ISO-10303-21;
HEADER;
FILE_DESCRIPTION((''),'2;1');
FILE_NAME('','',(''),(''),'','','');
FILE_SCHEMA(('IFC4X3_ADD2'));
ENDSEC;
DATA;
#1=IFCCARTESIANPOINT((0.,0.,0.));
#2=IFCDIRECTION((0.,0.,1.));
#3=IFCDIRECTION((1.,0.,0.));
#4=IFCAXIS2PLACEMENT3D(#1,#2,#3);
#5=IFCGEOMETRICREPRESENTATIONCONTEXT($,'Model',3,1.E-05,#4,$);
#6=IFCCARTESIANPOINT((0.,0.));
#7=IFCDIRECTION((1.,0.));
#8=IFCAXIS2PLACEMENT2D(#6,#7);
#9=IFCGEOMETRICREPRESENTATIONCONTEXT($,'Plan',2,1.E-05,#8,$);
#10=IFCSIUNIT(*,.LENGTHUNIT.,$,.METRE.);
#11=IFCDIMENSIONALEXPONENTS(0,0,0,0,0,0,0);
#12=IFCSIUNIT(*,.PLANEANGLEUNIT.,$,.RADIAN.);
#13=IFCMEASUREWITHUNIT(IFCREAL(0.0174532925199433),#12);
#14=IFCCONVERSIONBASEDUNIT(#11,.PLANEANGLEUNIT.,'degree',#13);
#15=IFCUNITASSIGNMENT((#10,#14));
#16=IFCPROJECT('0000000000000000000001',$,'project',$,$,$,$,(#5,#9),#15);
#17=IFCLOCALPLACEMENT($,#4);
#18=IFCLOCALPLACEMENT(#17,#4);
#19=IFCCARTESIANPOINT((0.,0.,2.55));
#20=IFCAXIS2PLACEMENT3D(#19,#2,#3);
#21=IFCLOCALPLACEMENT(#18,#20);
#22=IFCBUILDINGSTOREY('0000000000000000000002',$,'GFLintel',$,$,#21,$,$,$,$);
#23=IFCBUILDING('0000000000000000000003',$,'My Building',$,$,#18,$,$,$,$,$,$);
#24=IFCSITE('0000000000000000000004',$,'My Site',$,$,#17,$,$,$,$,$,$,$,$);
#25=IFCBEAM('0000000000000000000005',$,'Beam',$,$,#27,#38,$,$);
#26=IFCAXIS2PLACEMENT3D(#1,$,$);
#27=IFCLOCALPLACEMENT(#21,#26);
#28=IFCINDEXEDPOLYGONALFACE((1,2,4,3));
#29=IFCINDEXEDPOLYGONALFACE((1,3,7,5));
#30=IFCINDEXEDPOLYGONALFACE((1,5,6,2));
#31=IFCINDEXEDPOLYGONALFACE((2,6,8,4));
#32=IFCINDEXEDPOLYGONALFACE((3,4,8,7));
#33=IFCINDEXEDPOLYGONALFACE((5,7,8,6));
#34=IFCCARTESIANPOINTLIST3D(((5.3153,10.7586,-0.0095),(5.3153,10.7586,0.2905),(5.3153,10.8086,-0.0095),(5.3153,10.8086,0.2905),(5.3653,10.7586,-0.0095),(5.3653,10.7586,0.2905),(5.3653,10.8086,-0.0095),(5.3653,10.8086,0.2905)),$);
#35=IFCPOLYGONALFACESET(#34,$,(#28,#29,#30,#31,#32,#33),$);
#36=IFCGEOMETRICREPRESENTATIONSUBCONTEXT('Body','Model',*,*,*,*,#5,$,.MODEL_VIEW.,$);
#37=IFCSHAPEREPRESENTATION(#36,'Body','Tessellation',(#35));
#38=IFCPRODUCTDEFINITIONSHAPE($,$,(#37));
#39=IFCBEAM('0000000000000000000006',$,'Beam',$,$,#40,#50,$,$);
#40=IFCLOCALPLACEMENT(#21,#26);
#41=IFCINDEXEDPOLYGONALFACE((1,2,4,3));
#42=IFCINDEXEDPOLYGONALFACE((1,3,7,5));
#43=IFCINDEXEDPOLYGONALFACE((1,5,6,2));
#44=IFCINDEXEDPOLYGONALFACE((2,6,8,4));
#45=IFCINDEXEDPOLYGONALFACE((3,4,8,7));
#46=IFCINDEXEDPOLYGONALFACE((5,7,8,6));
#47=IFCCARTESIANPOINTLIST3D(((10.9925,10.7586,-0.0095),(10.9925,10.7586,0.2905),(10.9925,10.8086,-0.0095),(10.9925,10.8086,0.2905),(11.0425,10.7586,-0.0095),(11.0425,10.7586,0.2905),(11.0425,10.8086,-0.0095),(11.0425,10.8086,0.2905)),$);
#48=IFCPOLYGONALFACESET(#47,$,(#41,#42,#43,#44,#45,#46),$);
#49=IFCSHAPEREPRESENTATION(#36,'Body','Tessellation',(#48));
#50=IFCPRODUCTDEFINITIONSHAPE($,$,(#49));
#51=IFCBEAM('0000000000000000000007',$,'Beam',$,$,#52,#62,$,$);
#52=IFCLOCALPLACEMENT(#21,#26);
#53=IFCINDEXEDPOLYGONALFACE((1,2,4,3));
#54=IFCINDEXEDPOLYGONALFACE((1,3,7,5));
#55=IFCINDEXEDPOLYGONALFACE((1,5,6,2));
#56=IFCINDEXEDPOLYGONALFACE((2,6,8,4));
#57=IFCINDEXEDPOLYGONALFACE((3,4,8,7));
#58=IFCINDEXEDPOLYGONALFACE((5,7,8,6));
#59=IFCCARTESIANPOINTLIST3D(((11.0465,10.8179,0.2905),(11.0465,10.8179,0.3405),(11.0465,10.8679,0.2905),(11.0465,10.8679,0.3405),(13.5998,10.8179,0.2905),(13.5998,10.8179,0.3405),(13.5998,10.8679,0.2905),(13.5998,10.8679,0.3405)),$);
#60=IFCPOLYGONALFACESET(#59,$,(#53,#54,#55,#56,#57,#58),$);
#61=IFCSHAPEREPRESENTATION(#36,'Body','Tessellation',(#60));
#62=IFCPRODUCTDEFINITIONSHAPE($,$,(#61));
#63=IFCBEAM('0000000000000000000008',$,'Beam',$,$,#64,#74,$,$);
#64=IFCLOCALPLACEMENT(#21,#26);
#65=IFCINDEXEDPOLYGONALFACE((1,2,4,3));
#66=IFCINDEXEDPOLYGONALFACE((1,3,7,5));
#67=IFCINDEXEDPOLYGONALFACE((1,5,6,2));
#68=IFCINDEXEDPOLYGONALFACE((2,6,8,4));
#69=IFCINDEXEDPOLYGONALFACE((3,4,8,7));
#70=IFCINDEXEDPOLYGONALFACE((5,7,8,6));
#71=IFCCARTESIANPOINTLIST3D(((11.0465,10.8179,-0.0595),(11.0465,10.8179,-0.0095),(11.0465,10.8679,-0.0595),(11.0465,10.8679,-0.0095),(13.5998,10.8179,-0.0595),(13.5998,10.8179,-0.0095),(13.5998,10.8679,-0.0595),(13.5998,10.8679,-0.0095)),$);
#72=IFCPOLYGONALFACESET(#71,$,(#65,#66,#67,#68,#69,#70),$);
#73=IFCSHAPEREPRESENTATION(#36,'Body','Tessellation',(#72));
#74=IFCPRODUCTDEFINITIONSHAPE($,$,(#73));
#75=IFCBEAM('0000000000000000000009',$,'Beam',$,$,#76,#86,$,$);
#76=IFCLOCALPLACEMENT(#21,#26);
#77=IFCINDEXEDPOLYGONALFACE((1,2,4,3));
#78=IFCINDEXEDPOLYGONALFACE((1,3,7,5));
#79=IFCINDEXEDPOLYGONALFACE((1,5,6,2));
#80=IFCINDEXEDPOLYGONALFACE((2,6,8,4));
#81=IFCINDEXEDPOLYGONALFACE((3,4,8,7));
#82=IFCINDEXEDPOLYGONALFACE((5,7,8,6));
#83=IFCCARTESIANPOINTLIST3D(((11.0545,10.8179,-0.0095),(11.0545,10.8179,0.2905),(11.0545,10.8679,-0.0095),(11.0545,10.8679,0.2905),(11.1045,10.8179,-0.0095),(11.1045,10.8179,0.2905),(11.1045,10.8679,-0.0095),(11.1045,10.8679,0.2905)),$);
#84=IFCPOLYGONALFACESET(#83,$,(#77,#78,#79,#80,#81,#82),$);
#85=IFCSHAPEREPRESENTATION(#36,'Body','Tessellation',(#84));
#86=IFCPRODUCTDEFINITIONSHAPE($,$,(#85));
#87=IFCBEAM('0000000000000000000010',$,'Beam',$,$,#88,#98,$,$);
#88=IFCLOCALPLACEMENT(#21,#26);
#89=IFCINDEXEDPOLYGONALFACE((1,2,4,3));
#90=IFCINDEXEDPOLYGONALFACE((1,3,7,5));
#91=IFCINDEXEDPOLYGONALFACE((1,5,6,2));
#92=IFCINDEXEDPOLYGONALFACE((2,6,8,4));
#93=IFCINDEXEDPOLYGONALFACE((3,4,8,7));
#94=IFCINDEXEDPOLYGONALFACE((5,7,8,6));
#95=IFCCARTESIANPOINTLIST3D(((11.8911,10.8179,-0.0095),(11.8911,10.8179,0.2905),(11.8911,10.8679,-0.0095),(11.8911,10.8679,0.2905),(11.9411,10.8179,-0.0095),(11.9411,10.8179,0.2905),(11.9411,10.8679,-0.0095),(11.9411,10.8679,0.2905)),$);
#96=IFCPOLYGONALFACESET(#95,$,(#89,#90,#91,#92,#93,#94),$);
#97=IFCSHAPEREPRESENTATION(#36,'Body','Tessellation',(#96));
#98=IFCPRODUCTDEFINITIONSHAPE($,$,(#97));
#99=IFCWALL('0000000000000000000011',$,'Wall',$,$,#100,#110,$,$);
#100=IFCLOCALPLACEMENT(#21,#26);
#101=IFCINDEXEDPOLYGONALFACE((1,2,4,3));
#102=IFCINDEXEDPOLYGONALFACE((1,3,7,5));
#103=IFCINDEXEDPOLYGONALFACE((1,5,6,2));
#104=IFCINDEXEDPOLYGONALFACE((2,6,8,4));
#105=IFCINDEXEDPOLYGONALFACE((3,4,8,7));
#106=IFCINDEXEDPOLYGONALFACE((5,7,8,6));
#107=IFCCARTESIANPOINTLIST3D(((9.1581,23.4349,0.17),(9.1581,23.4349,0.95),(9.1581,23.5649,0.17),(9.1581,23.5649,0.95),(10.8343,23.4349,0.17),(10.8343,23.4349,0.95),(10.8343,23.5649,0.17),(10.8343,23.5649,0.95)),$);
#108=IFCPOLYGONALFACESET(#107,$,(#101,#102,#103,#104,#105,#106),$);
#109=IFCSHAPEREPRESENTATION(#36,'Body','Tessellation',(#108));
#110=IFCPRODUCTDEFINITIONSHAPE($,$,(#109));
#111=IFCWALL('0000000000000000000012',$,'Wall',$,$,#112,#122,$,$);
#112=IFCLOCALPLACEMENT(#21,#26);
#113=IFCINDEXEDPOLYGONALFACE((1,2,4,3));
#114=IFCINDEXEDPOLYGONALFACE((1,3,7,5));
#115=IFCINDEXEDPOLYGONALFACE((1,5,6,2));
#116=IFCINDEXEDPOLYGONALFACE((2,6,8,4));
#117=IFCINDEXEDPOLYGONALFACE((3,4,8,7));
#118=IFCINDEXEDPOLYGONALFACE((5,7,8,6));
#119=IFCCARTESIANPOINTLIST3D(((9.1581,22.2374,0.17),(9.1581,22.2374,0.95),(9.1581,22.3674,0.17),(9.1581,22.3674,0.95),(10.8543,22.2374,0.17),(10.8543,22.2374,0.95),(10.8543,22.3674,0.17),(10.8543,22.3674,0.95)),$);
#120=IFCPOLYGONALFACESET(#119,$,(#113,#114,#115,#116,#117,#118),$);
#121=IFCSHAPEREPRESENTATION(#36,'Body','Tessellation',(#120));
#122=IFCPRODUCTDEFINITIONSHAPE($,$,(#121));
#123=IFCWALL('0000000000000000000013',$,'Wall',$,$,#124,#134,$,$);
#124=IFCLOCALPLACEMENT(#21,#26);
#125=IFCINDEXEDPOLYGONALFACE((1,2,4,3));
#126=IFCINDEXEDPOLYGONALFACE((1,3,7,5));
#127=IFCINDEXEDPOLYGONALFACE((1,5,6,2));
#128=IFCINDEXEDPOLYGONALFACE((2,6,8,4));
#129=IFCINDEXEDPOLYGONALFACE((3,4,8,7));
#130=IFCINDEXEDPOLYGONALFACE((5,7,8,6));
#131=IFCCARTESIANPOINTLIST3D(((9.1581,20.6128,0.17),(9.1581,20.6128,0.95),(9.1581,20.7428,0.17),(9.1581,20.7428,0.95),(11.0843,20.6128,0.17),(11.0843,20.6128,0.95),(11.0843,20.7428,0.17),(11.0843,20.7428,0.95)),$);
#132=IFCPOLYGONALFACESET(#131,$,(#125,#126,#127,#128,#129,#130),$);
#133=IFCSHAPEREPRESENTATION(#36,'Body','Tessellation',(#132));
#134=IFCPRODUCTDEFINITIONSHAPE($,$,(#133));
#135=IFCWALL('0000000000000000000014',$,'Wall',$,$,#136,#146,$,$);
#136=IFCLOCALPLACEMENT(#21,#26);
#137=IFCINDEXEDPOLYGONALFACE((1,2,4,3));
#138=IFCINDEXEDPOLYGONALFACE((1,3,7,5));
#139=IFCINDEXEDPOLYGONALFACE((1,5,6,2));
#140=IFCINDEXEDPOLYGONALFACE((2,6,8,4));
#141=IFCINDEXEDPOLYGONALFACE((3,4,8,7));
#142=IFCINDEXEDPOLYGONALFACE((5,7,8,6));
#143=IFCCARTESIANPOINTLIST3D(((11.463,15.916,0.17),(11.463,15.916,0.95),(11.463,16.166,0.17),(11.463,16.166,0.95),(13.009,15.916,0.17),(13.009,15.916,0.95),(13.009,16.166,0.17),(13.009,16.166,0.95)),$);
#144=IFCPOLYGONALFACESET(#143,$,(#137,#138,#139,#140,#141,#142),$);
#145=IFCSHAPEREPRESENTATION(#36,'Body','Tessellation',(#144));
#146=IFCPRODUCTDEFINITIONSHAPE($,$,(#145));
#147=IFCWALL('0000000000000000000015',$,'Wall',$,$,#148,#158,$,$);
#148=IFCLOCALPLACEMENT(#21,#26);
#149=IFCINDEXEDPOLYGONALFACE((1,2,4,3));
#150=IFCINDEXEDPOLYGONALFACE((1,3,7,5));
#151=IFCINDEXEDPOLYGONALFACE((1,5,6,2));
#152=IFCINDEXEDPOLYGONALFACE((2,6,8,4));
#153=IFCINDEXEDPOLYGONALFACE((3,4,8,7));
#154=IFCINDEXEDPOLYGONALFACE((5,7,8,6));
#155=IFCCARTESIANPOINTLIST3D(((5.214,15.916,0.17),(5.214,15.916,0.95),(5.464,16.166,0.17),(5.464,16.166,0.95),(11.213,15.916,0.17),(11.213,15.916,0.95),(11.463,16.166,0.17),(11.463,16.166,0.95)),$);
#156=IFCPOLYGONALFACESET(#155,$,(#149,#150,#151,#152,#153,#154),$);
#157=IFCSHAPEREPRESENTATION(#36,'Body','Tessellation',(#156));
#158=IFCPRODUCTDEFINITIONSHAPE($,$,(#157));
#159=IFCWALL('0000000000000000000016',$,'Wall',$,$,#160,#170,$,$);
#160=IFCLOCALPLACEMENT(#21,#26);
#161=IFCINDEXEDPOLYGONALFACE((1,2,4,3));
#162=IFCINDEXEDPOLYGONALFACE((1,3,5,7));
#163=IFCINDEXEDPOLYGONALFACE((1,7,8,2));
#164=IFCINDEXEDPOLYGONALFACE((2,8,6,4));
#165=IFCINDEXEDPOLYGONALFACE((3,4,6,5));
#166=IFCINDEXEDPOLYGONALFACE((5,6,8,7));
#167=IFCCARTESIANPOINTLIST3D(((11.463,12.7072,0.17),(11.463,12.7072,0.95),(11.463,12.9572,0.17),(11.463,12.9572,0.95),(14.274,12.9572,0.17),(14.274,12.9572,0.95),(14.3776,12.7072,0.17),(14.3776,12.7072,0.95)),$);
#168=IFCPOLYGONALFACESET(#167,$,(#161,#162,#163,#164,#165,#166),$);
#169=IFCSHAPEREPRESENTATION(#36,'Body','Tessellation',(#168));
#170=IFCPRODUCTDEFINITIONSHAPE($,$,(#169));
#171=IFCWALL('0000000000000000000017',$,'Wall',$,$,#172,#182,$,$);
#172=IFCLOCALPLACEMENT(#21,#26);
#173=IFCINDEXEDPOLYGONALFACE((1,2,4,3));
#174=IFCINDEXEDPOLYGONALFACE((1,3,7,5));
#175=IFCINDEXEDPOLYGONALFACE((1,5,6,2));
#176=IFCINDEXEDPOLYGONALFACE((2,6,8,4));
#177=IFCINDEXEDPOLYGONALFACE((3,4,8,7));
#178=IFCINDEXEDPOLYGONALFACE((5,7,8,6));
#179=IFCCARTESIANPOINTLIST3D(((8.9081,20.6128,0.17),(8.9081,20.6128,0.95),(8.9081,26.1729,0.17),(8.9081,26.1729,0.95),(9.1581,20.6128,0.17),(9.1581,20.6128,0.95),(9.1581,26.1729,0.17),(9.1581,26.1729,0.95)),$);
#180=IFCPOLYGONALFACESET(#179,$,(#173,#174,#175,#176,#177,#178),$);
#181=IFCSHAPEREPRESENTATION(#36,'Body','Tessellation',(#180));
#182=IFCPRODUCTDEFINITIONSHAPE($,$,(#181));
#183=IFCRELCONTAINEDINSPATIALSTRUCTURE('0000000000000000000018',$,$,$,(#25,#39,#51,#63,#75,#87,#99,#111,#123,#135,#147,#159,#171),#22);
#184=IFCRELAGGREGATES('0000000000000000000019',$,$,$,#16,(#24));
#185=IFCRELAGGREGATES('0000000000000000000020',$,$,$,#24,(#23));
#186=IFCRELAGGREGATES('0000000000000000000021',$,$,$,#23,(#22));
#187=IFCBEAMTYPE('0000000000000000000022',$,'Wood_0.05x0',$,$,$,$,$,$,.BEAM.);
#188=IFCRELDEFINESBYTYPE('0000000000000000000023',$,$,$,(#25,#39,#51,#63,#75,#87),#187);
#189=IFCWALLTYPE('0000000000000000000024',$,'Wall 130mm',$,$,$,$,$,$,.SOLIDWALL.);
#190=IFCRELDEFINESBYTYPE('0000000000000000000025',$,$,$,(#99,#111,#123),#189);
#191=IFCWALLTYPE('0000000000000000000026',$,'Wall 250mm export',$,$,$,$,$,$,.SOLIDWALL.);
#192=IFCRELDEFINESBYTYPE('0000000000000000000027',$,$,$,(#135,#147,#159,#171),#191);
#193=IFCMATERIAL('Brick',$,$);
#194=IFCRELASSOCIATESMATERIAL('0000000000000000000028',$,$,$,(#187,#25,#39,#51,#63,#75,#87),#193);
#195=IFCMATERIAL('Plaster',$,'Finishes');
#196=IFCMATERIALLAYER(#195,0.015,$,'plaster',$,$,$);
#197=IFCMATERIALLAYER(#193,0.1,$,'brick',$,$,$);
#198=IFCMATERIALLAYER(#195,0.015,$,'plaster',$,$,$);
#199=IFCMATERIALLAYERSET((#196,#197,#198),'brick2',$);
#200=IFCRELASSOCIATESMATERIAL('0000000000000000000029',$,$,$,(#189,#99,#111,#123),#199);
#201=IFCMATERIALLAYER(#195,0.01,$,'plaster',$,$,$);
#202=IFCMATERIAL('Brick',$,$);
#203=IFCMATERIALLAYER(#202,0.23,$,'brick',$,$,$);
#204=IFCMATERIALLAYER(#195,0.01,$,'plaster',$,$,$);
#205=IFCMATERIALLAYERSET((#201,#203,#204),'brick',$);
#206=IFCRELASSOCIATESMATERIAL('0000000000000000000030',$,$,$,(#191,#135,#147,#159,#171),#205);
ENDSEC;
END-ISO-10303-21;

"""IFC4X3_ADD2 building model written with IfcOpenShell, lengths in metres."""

from ifc_helpers import new_model, entity, si_unit, converted_unit, frame, origin_with_axes, origin_2d_with_axis, place, context, subcontext, project, spatial, line, indexed_curve, rectangle, outline, extrude, material, layer, layer_set, layer_usage, material_profile, profile_set, profile_usage, type_object, element, save


model = new_model("IFC4X3_ADD2")

# Units and contexts
model_context = context("Model", 3, precision=1e-05, world=origin_with_axes())
plan_context = context("Plan", 2, precision=1e-05, world=origin_2d_with_axis())
body_context = subcontext(model_context, "Body", "Model", "MODEL_VIEW")
ifc_project = project(units=[si_unit("LENGTHUNIT", "METRE"), converted_unit("PLANEANGLEUNIT", "degree", entity("IfcReal", 0.0174532925199433), si_unit("PLANEANGLEUNIT", "RADIAN"), dimensions=[0, 0, 0, 0, 0, 0, 0])], contexts=[model_context, plan_context])

# Site, building, storey
site_placement = place(None, origin_with_axes())
site = spatial("IfcSite", under=ifc_project, at=site_placement, Name="My Site")
building_placement = place(site_placement, origin_with_axes())
building = spatial("IfcBuilding", under=site, at=building_placement, Name="My Building")
storey_placement = place(building_placement, frame((0.0, 0.0, 2.55), z_axis=(0.0, 0.0, 1.0), x_axis=(1.0, 0.0, 0.0)))
storey = spatial("IfcBuildingStorey", under=building, at=storey_placement, Name="GFLintel")

# Beams
ifc_material_1 = material(Name="Brick")
ifc_material_profile_1 = material_profile(ifc_material_1, rectangle(XDim=0.05, YDim=0.05))
ifc_profile_set_1 = profile_set([ifc_material_profile_1])
ifc_profile_usage_1 = profile_usage(ifc_profile_set_1, cardinal=5)
beam_type_1 = type_object("IfcBeamType", Name="Wood_0.05x0", PredefinedType="BEAM", material=ifc_profile_set_1)
beam_1_placement = place(storey_placement, frame((5.3403, 10.7836, -0.0095), z_axis=(0.0, -0.000001, 1.0), x_axis=(-1.0, 0.0, 0.0)))
element("IfcBeam", 1, at=beam_1_placement, inside=storey, type_object=beam_type_1, material=ifc_profile_usage_1, Name="Beam", context=body_context, shape_type="SweptSolid", body=[
    extrude(rectangle(XDim=0.05, YDim=0.05), origin_with_axes(), (0.0, 0.0, 1.0), 0.3),
])
ifc_profile_usage_2 = profile_usage(ifc_profile_set_1, cardinal=5)
beam_2_placement = place(storey_placement, frame((11.0175, 10.7836, -0.0095), z_axis=(0.0, -0.000001, 1.0), x_axis=(-1.0, 0.0, 0.0)))
element("IfcBeam", 2, at=beam_2_placement, inside=storey, type_object=beam_type_1, material=ifc_profile_usage_2, Name="Beam", context=body_context, shape_type="SweptSolid", body=[
    extrude(rectangle(XDim=0.05, YDim=0.05), origin_with_axes(), (0.0, 0.0, 1.0), 0.3),
])
ifc_profile_usage_3 = profile_usage(ifc_profile_set_1, cardinal=5)
beam_3_placement = place(storey_placement, frame((11.0465, 10.8429, 0.3155), z_axis=(1.0, 0.0, 0.000001), x_axis=(0.0, 1.0, 0.0)))
element("IfcBeam", 3, at=beam_3_placement, inside=storey, type_object=beam_type_1, material=ifc_profile_usage_3, Name="Beam", context=body_context, shape_type="SweptSolid", body=[
    extrude(rectangle(XDim=0.05, YDim=0.05), origin_with_axes(), (0.0, 0.0, 1.0), 2.5534),
])
ifc_profile_usage_4 = profile_usage(ifc_profile_set_1, cardinal=5)
beam_4_placement = place(storey_placement, frame((11.0465, 10.8429, -0.0345), z_axis=(1.0, 0.0, 0.000001), x_axis=(0.0, 1.0, 0.0)))
element("IfcBeam", 4, at=beam_4_placement, inside=storey, type_object=beam_type_1, material=ifc_profile_usage_4, Name="Beam", context=body_context, shape_type="SweptSolid", body=[
    extrude(rectangle(XDim=0.05, YDim=0.05), origin_with_axes(), (0.0, 0.0, 1.0), 2.5534),
])
ifc_profile_usage_5 = profile_usage(ifc_profile_set_1, cardinal=5)
beam_5_placement = place(storey_placement, frame((11.0795, 10.8429, -0.0095), z_axis=(-0.000001, 0.0, 1.0), x_axis=(0.0, 1.0, 0.0)))
element("IfcBeam", 5, at=beam_5_placement, inside=storey, type_object=beam_type_1, material=ifc_profile_usage_5, Name="Beam", context=body_context, shape_type="SweptSolid", body=[
    extrude(rectangle(XDim=0.05, YDim=0.05), origin_with_axes(), (0.0, 0.0, 1.0), 0.3),
])
ifc_profile_usage_6 = profile_usage(ifc_profile_set_1, cardinal=5)
beam_6_placement = place(storey_placement, frame((11.9161, 10.8429, -0.0095), z_axis=(-0.000001, 0.0, 1.0), x_axis=(0.0, 1.0, 0.0)))
element("IfcBeam", 6, at=beam_6_placement, inside=storey, type_object=beam_type_1, material=ifc_profile_usage_6, Name="Beam", context=body_context, shape_type="SweptSolid", body=[
    extrude(rectangle(XDim=0.05, YDim=0.05), origin_with_axes(), (0.0, 0.0, 1.0), 0.3),
])

# Walls
ifc_material_2 = material(Name="Plaster", Category="Finishes")
ifc_layer_1 = layer(ifc_material_2, 0.015, Name="plaster")
ifc_layer_2 = layer(ifc_material_1, 0.1, Name="brick")
ifc_layer_3 = layer(ifc_material_2, 0.015, Name="plaster")
ifc_layer_set_1 = layer_set([ifc_layer_1, ifc_layer_2, ifc_layer_3], Name="brick2")
ifc_layer_usage_1 = layer_usage(ifc_layer_set_1, "AXIS2", "POSITIVE", 0.0)
wall_type_1 = type_object("IfcWallType", Name="Wall 130mm", PredefinedType="SOLIDWALL", material=ifc_layer_set_1)
wall_1_placement = place(storey_placement, frame((9.1581, 23.4349, 0.17), z_axis=(0.0, 0.0, 1.0), x_axis=(1.0, 0.0, 0.0)))
element("IfcWall", 7, at=wall_1_placement, inside=storey, type_object=wall_type_1, material=ifc_layer_usage_1, Name="Wall", context=body_context, shape_type="SweptSolid", body=[
    extrude(outline(indexed_curve([(0.0, 0.0), (0.0, 0.13), (1.6762, 0.13), (1.6762, 0.0)], segments=[line(1, 2, 3, 4, 1)])), origin_with_axes(), (0.0, 0.0, 1.0), 0.78),
])
ifc_layer_usage_2 = layer_usage(ifc_layer_set_1, "AXIS2", "POSITIVE", 0.0)
wall_2_placement = place(storey_placement, frame((9.1581, 22.2374, 0.17), z_axis=(0.0, 0.0, 1.0), x_axis=(1.0, 0.0, 0.0)))
element("IfcWall", 8, at=wall_2_placement, inside=storey, type_object=wall_type_1, material=ifc_layer_usage_2, Name="Wall", context=body_context, shape_type="SweptSolid", body=[
    extrude(outline(indexed_curve([(0.0, 0.0), (0.0, 0.13), (1.6962, 0.13), (1.6962, 0.0)], segments=[line(1, 2, 3, 4, 1)])), origin_with_axes(), (0.0, 0.0, 1.0), 0.78),
])
ifc_layer_usage_3 = layer_usage(ifc_layer_set_1, "AXIS2", "POSITIVE", 0.0)
wall_3_placement = place(storey_placement, frame((9.1581, 20.6128, 0.17), z_axis=(0.0, 0.0, 1.0), x_axis=(1.0, 0.0, 0.0)))
element("IfcWall", 9, at=wall_3_placement, inside=storey, type_object=wall_type_1, material=ifc_layer_usage_3, Name="Wall", context=body_context, shape_type="SweptSolid", body=[
    extrude(outline(indexed_curve([(0.0, 0.0), (0.0, 0.13), (1.9262, 0.13), (1.9262, 0.0)], segments=[line(1, 2, 3, 4, 1)])), origin_with_axes(), (0.0, 0.0, 1.0), 0.78),
])
ifc_layer_4 = layer(ifc_material_2, 0.01, Name="plaster")
ifc_material_3 = material(Name="Brick")
ifc_layer_5 = layer(ifc_material_3, 0.23, Name="brick")
ifc_layer_6 = layer(ifc_material_2, 0.01, Name="plaster")
ifc_layer_set_2 = layer_set([ifc_layer_4, ifc_layer_5, ifc_layer_6], Name="brick")
ifc_layer_usage_4 = layer_usage(ifc_layer_set_2, "AXIS2", "POSITIVE", 0.0)
wall_type_2 = type_object("IfcWallType", Name="Wall 250mm export", PredefinedType="SOLIDWALL", material=ifc_layer_set_2)
wall_4_placement = place(storey_placement, frame((11.463, 15.916, 0.17), z_axis=(0.0, 0.0, 1.0), x_axis=(1.0, 0.0, 0.0)))
element("IfcWall", 10, at=wall_4_placement, inside=storey, type_object=wall_type_2, material=ifc_layer_usage_4, Name="Wall", context=body_context, shape_type="SweptSolid", body=[
    extrude(outline(indexed_curve([(0.0, 0.0), (0.0, 0.25), (1.546, 0.25), (1.546, 0.0)], segments=[line(1, 2, 3, 4, 1)])), origin_with_axes(), (0.0, 0.0, 1.0), 0.78),
])
ifc_layer_usage_5 = layer_usage(ifc_layer_set_2, "AXIS2", "POSITIVE", 0.0)
wall_5_placement = place(storey_placement, frame((5.464, 15.916, 0.17), z_axis=(0.0, 0.0, 1.0), x_axis=(1.0, 0.0, 0.0)))
element("IfcWall", 11, at=wall_5_placement, inside=storey, type_object=wall_type_2, material=ifc_layer_usage_5, Name="Wall", context=body_context, shape_type="SweptSolid", body=[
    extrude(outline(indexed_curve([(-0.25, 0.0), (0.0, 0.25), (5.999, 0.25), (5.749, 0.0)], segments=[line(1, 2, 3, 4, 1)])), origin_with_axes(), (0.0, 0.0, 1.0), 0.78),
])
ifc_layer_usage_6 = layer_usage(ifc_layer_set_2, "AXIS2", "POSITIVE", 0.0)
wall_6_placement = place(storey_placement, frame((11.463, 12.7072, 0.17), z_axis=(0.0, 0.0, 1.0), x_axis=(1.0, 0.0, 0.0)))
element("IfcWall", 12, at=wall_6_placement, inside=storey, type_object=wall_type_2, material=ifc_layer_usage_6, Name="Wall", context=body_context, shape_type="SweptSolid", body=[
    extrude(outline(indexed_curve([(0.0, 0.0), (0.0, 0.25), (2.811, 0.25), (2.9146, 0.0)], segments=[line(1, 2, 3, 4, 1)])), origin_with_axes(), (0.0, 0.0, 1.0), 0.78),
])
ifc_layer_usage_7 = layer_usage(ifc_layer_set_2, "AXIS2", "POSITIVE", 0.0)
wall_7_placement = place(storey_placement, frame((9.1581, 20.6128, 0.17), z_axis=(0.0, 0.0, 1.0), x_axis=(0.0, 1.0, 0.0)))
element("IfcWall", 13, at=wall_7_placement, inside=storey, type_object=wall_type_2, material=ifc_layer_usage_7, Name="Wall", context=body_context, shape_type="SweptSolid", body=[
    extrude(outline(indexed_curve([(0.0, 0.0), (0.0, 0.25), (5.5601, 0.25), (5.5601, 0.0)], segments=[line(1, 2, 3, 4, 1)])), origin_with_axes(), (0.0, 0.0, 1.0), 0.78),
])

save(model, "model.ifc")
